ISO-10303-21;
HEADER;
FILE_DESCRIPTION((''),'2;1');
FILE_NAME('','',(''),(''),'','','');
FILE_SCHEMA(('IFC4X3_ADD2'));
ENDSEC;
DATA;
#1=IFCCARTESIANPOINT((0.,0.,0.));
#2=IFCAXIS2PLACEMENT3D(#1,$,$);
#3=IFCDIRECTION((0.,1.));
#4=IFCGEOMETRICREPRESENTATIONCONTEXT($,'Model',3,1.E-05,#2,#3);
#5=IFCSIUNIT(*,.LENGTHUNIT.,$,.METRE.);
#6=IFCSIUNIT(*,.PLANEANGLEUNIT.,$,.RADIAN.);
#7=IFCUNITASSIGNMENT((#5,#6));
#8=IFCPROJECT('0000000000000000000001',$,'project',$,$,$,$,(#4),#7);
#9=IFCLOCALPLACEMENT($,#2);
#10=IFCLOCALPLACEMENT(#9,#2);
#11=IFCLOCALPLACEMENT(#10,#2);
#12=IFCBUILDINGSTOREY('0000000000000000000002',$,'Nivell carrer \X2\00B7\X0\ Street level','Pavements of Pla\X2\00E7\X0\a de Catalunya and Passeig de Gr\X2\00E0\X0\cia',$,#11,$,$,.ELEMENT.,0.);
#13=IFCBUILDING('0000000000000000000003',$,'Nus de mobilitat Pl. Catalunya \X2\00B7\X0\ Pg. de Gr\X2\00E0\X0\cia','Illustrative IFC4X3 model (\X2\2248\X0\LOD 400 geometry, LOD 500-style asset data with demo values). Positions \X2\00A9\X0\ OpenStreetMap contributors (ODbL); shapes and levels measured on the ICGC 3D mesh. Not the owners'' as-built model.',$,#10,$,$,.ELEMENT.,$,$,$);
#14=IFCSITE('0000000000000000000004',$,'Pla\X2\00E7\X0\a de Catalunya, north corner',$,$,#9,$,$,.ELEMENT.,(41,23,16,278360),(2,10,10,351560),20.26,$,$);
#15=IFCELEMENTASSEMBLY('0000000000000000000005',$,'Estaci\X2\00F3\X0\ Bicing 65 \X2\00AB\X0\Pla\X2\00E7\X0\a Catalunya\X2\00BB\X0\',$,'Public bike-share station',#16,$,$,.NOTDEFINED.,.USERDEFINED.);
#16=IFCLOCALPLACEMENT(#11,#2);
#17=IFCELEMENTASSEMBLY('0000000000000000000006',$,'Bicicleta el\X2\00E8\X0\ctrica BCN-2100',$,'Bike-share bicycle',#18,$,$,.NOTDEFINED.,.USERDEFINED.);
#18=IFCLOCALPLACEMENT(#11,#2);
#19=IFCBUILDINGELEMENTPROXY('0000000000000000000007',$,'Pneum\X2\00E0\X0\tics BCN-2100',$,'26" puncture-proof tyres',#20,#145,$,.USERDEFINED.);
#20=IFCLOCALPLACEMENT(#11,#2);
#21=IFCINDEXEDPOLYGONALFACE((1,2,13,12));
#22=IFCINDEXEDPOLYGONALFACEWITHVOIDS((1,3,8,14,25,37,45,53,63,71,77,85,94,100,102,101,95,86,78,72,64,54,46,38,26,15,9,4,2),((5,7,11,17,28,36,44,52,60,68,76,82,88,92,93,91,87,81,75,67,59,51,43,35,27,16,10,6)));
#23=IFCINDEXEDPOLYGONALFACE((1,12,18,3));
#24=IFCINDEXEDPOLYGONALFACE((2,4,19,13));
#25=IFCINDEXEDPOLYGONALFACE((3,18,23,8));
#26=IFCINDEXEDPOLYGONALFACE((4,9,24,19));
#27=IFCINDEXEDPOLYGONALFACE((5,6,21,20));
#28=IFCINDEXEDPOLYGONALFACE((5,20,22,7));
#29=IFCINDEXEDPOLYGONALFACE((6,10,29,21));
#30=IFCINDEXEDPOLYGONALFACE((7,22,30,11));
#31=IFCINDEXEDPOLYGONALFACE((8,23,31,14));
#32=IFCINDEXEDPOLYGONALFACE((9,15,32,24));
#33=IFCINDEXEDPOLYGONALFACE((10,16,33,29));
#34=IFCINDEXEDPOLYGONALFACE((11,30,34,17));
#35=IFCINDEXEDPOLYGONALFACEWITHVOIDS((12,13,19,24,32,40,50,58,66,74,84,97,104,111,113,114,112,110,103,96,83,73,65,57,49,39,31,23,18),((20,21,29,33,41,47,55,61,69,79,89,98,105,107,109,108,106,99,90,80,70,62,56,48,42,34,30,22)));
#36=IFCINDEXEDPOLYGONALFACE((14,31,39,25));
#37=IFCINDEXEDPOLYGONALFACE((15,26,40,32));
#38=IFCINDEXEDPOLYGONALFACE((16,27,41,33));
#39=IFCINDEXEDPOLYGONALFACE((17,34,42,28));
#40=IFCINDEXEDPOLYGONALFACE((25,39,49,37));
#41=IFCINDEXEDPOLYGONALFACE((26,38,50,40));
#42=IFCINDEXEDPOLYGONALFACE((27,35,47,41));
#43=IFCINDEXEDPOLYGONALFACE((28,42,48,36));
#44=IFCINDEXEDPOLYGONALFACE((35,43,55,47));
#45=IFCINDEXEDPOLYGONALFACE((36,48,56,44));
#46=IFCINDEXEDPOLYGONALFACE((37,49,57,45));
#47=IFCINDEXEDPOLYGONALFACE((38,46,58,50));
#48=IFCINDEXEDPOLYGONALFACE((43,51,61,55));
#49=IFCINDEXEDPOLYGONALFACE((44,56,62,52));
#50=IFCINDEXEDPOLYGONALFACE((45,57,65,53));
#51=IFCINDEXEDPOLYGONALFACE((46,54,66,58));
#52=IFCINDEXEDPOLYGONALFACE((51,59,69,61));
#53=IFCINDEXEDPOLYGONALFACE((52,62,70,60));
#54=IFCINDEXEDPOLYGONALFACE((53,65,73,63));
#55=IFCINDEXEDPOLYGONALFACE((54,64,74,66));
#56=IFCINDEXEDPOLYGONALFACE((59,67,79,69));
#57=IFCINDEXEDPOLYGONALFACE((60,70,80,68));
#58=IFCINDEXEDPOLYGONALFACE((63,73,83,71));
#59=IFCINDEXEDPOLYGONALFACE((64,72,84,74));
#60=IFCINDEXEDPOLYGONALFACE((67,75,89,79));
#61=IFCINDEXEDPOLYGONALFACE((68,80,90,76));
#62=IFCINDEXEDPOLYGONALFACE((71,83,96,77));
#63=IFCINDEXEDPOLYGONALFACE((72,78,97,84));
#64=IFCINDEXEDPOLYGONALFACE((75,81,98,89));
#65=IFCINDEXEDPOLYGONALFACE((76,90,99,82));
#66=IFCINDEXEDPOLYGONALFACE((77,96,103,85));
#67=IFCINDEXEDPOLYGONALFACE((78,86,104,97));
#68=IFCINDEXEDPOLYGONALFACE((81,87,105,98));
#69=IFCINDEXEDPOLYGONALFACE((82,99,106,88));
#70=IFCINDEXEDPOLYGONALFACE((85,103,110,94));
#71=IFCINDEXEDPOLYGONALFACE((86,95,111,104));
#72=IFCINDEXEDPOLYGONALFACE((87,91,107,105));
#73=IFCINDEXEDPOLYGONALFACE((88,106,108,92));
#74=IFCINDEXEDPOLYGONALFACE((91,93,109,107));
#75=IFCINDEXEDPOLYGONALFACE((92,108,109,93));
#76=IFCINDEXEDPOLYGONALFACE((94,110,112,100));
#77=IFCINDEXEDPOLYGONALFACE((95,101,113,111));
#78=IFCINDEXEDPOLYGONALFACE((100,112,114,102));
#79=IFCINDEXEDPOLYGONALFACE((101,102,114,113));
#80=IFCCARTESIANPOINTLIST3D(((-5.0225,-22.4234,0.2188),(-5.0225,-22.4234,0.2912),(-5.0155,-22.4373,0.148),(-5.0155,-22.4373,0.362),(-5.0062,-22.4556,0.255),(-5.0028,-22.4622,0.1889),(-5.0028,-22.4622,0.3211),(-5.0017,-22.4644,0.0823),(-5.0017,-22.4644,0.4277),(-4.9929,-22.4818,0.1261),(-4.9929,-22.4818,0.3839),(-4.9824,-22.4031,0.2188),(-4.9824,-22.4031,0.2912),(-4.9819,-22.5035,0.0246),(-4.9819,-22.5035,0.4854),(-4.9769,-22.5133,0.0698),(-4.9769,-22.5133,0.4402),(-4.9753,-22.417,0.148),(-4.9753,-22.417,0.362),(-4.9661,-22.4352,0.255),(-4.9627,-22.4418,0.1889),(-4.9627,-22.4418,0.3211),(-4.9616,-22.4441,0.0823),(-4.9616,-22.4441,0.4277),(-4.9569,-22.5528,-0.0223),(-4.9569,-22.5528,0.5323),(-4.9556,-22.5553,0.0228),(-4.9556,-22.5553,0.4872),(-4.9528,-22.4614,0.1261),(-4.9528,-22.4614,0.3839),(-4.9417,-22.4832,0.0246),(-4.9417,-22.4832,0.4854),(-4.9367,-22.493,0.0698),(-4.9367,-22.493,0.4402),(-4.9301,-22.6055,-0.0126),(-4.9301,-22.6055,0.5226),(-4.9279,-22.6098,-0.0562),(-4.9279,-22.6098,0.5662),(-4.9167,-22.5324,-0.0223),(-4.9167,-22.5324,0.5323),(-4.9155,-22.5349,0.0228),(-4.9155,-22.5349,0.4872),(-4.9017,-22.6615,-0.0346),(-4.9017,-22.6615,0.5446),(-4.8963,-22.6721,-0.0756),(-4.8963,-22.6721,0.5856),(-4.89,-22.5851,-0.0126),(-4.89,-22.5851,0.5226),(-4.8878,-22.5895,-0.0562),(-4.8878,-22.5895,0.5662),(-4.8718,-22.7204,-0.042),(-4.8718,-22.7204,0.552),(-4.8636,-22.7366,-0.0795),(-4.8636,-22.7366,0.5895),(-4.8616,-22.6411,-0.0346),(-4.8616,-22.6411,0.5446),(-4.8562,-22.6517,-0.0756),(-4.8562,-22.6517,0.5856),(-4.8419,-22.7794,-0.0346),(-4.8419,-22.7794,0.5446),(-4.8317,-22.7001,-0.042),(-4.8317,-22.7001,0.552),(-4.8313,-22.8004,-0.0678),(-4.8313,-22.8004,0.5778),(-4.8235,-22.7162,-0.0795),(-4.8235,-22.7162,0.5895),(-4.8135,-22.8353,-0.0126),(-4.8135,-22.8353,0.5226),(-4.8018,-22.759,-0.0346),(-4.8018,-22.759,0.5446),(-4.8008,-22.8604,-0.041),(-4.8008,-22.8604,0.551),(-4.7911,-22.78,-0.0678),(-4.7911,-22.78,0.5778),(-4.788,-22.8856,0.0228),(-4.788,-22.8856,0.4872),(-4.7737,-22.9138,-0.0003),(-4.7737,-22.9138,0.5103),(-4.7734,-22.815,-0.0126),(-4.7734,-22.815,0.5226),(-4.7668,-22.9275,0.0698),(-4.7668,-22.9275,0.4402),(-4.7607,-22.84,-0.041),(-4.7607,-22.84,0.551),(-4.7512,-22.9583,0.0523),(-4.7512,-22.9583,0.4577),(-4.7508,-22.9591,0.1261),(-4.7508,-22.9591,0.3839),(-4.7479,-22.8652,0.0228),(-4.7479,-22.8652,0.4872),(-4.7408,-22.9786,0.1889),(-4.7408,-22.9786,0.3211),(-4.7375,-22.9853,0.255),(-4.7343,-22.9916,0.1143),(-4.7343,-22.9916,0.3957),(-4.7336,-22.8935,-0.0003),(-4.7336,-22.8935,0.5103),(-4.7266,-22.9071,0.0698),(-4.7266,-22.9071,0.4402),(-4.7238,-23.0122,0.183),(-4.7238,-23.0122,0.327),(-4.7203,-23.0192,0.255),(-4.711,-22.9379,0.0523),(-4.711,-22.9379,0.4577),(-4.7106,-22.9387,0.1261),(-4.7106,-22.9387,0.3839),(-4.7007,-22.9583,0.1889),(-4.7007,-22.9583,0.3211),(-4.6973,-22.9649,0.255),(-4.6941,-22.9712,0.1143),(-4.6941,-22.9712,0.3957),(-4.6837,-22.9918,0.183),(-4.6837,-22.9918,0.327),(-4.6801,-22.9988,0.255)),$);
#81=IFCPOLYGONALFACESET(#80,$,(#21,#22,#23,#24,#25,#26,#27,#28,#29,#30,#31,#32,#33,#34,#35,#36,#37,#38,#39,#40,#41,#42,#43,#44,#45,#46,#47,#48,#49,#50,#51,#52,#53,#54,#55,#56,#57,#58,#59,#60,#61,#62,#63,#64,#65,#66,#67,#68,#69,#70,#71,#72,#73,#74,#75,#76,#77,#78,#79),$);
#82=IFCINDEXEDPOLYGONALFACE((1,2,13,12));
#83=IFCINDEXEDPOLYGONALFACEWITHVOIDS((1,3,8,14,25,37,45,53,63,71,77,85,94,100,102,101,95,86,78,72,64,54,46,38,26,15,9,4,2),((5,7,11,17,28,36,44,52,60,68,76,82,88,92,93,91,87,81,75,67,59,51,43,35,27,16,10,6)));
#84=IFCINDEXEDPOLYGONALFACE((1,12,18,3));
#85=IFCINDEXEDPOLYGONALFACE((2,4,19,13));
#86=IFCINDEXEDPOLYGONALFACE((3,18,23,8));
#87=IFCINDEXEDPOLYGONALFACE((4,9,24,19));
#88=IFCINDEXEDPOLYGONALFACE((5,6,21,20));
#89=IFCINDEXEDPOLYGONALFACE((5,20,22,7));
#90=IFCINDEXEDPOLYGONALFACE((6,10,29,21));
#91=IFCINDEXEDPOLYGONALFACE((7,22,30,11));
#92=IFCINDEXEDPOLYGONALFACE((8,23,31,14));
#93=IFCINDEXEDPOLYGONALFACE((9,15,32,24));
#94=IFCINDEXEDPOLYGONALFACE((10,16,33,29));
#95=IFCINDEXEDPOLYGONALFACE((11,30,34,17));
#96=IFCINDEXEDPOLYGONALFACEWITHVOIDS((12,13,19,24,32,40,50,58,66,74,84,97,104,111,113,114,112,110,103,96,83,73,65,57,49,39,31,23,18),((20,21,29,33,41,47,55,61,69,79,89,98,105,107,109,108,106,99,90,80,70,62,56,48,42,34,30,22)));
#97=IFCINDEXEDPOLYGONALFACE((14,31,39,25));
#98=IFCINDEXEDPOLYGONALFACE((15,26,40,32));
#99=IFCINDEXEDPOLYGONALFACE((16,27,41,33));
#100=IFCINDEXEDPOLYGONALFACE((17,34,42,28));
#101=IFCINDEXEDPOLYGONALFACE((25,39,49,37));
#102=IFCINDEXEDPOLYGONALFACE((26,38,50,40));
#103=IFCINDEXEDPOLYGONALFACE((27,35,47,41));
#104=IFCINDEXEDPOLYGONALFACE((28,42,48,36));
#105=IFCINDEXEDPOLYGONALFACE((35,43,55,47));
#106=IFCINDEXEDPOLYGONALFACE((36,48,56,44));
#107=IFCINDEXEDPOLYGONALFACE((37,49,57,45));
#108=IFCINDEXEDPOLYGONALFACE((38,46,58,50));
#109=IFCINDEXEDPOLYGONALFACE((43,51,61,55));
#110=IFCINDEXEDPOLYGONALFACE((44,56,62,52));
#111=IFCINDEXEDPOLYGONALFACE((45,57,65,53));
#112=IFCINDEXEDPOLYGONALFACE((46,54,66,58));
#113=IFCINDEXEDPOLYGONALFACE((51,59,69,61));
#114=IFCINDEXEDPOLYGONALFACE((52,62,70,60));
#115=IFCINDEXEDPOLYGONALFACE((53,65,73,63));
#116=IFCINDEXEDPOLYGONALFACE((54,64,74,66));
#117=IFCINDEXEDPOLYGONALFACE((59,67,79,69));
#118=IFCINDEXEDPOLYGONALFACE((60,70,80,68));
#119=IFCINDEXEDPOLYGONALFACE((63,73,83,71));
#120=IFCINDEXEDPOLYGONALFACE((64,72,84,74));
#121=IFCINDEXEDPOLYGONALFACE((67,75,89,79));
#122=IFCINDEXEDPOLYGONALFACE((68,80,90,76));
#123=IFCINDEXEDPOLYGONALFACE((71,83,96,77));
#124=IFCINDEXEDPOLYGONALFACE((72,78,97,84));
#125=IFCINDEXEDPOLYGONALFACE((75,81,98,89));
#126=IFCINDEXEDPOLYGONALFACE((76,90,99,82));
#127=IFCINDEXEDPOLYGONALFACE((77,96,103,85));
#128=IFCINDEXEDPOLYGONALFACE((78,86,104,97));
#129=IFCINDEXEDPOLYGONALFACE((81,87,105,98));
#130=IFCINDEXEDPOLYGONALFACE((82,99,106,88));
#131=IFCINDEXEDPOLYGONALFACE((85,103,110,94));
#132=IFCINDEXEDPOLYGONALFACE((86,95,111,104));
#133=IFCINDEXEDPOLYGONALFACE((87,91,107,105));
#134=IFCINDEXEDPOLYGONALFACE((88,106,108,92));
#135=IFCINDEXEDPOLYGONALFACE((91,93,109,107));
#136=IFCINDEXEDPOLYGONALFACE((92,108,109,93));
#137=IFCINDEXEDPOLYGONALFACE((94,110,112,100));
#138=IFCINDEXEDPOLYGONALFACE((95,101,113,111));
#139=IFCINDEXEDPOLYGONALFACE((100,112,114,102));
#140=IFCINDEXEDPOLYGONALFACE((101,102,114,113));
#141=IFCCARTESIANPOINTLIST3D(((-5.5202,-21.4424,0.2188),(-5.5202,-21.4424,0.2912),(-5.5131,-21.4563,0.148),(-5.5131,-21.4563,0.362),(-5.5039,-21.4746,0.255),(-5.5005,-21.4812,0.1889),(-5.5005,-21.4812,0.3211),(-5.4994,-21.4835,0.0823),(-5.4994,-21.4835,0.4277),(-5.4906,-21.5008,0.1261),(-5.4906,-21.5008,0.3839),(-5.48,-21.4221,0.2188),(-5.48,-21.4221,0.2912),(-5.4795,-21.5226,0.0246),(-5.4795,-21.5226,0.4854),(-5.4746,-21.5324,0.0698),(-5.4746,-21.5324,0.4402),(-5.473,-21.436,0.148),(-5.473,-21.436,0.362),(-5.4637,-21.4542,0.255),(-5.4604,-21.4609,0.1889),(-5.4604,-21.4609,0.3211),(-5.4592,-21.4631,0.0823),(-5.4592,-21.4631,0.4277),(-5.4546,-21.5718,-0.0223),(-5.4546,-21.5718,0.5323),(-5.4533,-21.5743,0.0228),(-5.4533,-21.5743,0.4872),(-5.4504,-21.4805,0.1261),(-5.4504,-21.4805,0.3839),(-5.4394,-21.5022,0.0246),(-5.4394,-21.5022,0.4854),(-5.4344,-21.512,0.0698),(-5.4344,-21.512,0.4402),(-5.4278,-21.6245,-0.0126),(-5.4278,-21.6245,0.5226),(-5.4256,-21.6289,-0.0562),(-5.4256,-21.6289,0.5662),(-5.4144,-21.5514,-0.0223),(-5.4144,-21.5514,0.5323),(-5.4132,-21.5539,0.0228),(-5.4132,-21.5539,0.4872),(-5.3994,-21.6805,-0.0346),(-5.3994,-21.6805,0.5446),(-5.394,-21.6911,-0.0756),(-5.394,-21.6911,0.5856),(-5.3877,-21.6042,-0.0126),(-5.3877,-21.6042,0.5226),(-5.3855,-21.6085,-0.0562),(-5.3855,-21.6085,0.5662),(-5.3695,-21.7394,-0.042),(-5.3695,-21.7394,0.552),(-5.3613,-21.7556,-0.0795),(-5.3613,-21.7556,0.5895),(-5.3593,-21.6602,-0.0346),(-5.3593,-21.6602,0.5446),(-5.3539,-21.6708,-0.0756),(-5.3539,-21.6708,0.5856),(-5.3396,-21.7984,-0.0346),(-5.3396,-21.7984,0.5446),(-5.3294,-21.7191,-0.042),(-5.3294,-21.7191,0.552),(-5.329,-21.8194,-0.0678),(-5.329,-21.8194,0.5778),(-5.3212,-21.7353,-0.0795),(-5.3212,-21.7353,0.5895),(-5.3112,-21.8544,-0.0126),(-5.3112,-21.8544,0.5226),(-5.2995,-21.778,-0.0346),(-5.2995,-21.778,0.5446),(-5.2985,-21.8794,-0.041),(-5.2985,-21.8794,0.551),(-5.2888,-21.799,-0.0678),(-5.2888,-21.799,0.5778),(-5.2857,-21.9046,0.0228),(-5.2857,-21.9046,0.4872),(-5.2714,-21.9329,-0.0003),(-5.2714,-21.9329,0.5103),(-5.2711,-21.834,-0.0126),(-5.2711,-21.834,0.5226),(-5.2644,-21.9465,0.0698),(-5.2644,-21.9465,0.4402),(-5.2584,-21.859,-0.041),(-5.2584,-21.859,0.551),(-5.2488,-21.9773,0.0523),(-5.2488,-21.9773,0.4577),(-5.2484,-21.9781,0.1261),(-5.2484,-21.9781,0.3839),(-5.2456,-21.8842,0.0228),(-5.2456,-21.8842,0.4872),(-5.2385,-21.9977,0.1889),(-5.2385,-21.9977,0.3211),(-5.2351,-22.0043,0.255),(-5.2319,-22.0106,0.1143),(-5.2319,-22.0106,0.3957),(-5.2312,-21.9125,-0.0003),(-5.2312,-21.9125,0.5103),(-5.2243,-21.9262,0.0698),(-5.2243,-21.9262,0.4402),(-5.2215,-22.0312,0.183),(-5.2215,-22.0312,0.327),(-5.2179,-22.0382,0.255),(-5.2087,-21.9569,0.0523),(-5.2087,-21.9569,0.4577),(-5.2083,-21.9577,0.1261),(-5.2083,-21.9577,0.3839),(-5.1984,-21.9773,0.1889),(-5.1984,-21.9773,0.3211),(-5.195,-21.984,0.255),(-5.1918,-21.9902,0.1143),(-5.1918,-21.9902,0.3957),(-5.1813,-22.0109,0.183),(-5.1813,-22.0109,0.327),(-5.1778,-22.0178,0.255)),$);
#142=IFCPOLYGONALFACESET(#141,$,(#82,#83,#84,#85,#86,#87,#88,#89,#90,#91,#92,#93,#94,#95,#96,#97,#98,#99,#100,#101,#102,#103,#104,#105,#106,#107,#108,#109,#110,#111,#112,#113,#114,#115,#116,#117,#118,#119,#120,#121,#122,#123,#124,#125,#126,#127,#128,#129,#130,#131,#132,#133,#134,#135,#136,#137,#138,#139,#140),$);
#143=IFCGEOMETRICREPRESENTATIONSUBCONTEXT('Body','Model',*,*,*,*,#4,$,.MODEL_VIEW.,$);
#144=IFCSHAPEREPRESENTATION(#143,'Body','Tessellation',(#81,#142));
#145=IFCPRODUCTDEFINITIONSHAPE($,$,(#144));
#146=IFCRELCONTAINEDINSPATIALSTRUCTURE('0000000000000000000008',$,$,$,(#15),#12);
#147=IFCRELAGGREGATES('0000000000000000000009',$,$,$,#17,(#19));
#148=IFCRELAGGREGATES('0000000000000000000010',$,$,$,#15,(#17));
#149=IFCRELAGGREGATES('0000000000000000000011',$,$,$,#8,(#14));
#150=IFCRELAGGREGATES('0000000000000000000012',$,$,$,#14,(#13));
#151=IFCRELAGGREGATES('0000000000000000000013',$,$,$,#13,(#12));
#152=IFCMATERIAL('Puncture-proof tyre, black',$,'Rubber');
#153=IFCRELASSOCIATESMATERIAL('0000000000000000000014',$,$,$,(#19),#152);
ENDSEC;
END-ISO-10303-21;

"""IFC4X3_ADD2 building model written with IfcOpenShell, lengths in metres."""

from ifc_helpers import new_model, si_unit, direction, frame, origin, origin_2d_with_axis, place, context, subcontext, project, spatial, hollow_circle, extrude, material, element, aggregate, save


model = new_model("IFC4X3_ADD2")

# Units and contexts
model_context = context("Model", 3, precision=1e-05, world=origin(), true_north=direction((0.0, 1.0)))
body_context = subcontext(model_context, "Body", "Model", "MODEL_VIEW")
ifc_project = project(units=[si_unit("LENGTHUNIT", "METRE"), si_unit("PLANEANGLEUNIT", "RADIAN")], contexts=[model_context])

# Site, building, storey
site_placement = place(None, origin())
site = spatial("IfcSite", under=ifc_project, at=site_placement, Name="Plaça de Catalunya, north corner", CompositionType="ELEMENT", RefLatitude=(41, 23, 16, 278360), RefLongitude=(2, 10, 10, 351560), RefElevation=20.26)
building_placement = place(site_placement, origin())
building = spatial("IfcBuilding", under=site, at=building_placement, Name="Nus de mobilitat Pl. Catalunya · Pg. de Gràcia", Description="Illustrative IFC4X3 model (≈LOD 400 geometry, LOD 500-style asset data with demo values). Positions © OpenStreetMap contributors (ODbL); shapes and levels measured on the ICGC 3D mesh. Not the owners' as-built model.", CompositionType="ELEMENT")
storey_placement = place(building_placement, origin())
storey = spatial("IfcBuildingStorey", under=building, at=storey_placement, Name="Nivell carrer · Street level", Description="Pavements of Plaça de Catalunya and Passeig de Gràcia", CompositionType="ELEMENT", Elevation=0.0)

# Element assemblies, building element proxy
assembly_1_placement = place(building_placement, origin())
assembly_1 = element("IfcElementAssembly", 1, at=assembly_1_placement, inside=storey, Name="Estació Bicing 65 «Plaça Catalunya»", ObjectType="Public bike-share station", AssemblyPlace="NOTDEFINED", PredefinedType="USERDEFINED")
assembly_2_placement = place(building_placement, origin())
assembly_2 = element("IfcElementAssembly", 2, at=assembly_2_placement, Name="Bicicleta elèctrica BCN-2100", ObjectType="Bike-share bicycle", AssemblyPlace="NOTDEFINED", PredefinedType="USERDEFINED")
ifc_material_1 = material(Name="Puncture-proof tyre, black", Category="Rubber")
proxy_1_placement = place(building_placement, origin())
proxy_1 = element("IfcBuildingElementProxy", 3, at=proxy_1_placement, material=ifc_material_1, Name="Pneumàtics BCN-2100", ObjectType="26\" puncture-proof tyres", PredefinedType="USERDEFINED", context=body_context, shape_type="SweptSolid", body=[
    extrude(hollow_circle(Radius=0.335, WallThickness=0.038, at=origin_2d_with_axis()), frame((-4.8718, -22.7204, 0.255), z_axis=(0.891798, 0.452435, 0.0), x_axis=(0.452435, -0.891798, 0.0)), (0.0, 0.0, 1.0), 0.045),
    extrude(hollow_circle(Radius=0.335, WallThickness=0.038, at=origin_2d_with_axis()), frame((-5.3695, -21.7394, 0.255), z_axis=(0.891798, 0.452435, 0.0), x_axis=(0.452435, -0.891798, 0.0)), (0.0, 0.0, 1.0), 0.045),
])
aggregate(assembly_2, [proxy_1])
aggregate(assembly_1, [assembly_2])

save(model, "model.ifc")
